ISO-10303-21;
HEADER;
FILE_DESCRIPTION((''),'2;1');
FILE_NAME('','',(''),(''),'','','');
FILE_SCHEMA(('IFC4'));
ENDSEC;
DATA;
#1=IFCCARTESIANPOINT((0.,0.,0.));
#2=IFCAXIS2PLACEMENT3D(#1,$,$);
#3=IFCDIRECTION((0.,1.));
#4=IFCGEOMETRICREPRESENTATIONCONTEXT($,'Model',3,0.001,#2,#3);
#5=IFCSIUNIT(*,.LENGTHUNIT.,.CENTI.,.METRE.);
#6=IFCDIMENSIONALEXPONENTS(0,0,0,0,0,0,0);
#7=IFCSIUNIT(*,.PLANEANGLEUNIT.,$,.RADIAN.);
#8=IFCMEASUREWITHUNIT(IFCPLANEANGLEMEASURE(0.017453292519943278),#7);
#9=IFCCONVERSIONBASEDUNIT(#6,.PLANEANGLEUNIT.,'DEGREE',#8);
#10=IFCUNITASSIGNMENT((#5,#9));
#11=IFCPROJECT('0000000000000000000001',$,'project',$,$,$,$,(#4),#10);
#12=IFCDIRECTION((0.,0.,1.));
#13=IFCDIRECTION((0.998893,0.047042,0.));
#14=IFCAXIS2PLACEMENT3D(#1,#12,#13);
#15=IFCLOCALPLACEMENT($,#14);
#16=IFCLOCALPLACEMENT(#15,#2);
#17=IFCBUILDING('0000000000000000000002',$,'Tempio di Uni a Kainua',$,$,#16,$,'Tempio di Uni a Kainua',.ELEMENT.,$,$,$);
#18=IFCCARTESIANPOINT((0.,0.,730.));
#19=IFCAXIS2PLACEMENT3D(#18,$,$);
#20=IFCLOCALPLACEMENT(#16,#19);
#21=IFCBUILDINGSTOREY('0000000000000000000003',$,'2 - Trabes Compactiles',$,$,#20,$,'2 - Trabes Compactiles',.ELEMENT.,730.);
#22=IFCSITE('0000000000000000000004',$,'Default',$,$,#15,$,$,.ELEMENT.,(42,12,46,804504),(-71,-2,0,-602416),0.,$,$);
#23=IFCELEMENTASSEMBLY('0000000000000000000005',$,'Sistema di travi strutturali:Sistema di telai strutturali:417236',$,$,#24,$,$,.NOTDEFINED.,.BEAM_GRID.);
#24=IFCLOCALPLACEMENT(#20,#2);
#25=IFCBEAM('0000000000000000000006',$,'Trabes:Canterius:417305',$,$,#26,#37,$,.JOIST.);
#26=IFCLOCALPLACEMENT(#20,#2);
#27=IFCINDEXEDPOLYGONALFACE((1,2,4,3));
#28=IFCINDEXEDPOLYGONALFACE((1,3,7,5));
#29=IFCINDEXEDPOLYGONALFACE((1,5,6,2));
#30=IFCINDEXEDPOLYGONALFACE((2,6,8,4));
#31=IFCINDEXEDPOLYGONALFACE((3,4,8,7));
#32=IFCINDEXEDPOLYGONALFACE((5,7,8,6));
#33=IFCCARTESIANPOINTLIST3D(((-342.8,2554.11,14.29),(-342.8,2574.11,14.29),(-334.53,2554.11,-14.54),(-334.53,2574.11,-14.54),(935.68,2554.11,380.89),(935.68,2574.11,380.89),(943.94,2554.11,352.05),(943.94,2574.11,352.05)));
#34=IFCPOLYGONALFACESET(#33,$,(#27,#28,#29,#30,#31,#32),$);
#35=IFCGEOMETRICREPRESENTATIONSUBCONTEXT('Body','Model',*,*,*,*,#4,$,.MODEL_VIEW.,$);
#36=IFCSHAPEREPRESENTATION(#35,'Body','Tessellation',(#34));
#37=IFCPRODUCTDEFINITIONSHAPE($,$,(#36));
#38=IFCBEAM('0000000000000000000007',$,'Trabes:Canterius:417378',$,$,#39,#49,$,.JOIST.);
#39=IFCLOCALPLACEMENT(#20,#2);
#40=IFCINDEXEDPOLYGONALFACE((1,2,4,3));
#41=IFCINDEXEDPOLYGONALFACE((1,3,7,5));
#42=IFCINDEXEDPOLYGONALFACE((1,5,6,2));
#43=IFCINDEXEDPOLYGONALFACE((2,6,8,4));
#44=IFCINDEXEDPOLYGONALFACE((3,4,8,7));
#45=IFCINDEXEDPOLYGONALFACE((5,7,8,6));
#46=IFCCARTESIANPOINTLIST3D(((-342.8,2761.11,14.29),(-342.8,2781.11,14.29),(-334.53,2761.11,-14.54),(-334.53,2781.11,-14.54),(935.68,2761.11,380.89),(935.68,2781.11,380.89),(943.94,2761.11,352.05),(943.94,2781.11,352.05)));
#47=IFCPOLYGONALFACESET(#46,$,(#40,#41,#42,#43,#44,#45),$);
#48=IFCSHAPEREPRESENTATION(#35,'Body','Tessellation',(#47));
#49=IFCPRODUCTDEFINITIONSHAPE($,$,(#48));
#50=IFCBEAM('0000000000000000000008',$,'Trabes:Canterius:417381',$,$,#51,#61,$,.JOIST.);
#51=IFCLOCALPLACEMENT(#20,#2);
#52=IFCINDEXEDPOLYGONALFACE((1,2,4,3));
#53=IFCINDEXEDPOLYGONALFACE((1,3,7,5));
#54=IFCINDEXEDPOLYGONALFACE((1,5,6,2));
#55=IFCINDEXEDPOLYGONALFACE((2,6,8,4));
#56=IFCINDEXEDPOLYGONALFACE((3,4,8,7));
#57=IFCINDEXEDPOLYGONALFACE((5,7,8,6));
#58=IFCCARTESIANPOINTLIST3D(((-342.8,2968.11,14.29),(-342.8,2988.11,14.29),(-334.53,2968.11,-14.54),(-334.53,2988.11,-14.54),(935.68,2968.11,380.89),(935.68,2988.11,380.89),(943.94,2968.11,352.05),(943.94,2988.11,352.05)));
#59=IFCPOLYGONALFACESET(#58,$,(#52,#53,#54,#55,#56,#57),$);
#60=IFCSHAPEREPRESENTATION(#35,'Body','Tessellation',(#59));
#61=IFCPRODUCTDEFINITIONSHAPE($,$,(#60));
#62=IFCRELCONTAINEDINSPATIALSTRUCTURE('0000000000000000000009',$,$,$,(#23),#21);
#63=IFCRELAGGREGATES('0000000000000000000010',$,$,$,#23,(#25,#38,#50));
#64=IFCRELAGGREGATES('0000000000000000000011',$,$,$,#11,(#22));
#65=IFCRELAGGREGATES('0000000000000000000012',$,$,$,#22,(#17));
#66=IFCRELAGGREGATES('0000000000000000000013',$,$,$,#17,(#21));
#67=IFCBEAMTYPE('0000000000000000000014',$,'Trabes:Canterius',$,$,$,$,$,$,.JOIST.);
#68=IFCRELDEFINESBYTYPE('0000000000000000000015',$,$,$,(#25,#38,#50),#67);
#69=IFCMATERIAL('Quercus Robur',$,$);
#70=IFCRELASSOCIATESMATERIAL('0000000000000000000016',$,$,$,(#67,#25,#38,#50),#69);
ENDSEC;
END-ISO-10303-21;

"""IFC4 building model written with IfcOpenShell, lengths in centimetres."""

from ifc_helpers import new_model, entity, si_unit, converted_unit, direction, frame, origin, origin_2d_with_axis, place, context, subcontext, project, spatial, rectangle, extrude, source, transform, mapped, material, material_profile, profile_set, profile_usage, type_object, type_shapes, element, aggregate, save


model = new_model("IFC4")

# Units and contexts
model_context = context("Model", 3, precision=0.001, world=origin(), true_north=direction((0.0, 1.0)))
body_context = subcontext(model_context, "Body", "Model", "MODEL_VIEW")
ifc_project = project(units=[si_unit("LENGTHUNIT", "METRE", prefix="CENTI"), converted_unit("PLANEANGLEUNIT", "DEGREE", entity("IfcPlaneAngleMeasure", 0.017453292519943278), si_unit("PLANEANGLEUNIT", "RADIAN"), dimensions=[0, 0, 0, 0, 0, 0, 0])], contexts=[model_context])

# Site, building, storey
site_placement = place(None, frame((0.0, 0.0, 0.0), z_axis=(0.0, 0.0, 1.0), x_axis=(0.998893, 0.047042, 0.0)))
site = spatial("IfcSite", under=ifc_project, at=site_placement, Name="Default", CompositionType="ELEMENT", RefLatitude=(42, 12, 46, 804504), RefLongitude=(-71, -2, 0, -602416), RefElevation=0.0)
building_placement = place(site_placement, origin())
building = spatial("IfcBuilding", under=site, at=building_placement, Name="Tempio di Uni a Kainua", LongName="Tempio di Uni a Kainua", CompositionType="ELEMENT")
storey_placement = place(building_placement, frame((0.0, 0.0, 730.0)))
storey = spatial("IfcBuildingStorey", under=building, at=storey_placement, Name="2 - Trabes Compactiles", LongName="2 - Trabes Compactiles", CompositionType="ELEMENT", Elevation=730.0)

# Shared definitions
ifc_material = material(Name="Quercus Robur")

# Element assembly, beams
assembly_1_placement = place(storey_placement, origin())
assembly_1 = element("IfcElementAssembly", 1, at=assembly_1_placement, inside=storey, Name="Sistema di travi strutturali:Sistema di telai strutturali:417236", AssemblyPlace="NOTDEFINED", PredefinedType="BEAM_GRID")
ifc_material_profile_1 = material_profile(ifc_material, rectangle(XDim=2590.0, YDim=20.0, at=origin_2d_with_axis()), Name="Canterius")
ifc_profile_set_1 = profile_set([ifc_material_profile_1], Name="Canterius")
ifc_profile_usage_1 = profile_usage(ifc_profile_set_1, cardinal=8)
beam_type_1 = type_object("IfcBeamType", Name="Trabes:Canterius", PredefinedType="JOIST", material=ifc_profile_set_1)
shared_shape_1 = source(origin(), body_context, "Body", "SweptSolid", [
    extrude(rectangle(XDim=1330.0, YDim=20.0, at=origin_2d_with_axis()), frame((0.0, 0.0, -15.0)), (0.0, 0.0, 1.0), 30.0),
])
type_shapes(beam_type_1, [shared_shape_1])
beam_1_placement = place(assembly_1_placement, frame((300.57, 2564.11, 183.17), z_axis=(-0.275637, 0.0, 0.961262), x_axis=(0.961262, 0.0, 0.275637)))
beam_1 = element("IfcBeam", 2, at=beam_1_placement, type_object=beam_type_1, material=ifc_profile_usage_1, Name="Trabes:Canterius:417305", PredefinedType="JOIST", context=body_context, shape_type="MappedRepresentation", body=[
    mapped(shared_shape_1, transform((0.0, 0.0, 0.0), scale=1.0)),
])
beam_2_placement = place(assembly_1_placement, frame((300.57, 2771.11, 183.17), z_axis=(-0.275637, 0.0, 0.961262), x_axis=(0.961262, 0.0, 0.275637)))
beam_2 = element("IfcBeam", 3, at=beam_2_placement, type_object=beam_type_1, material=ifc_profile_usage_1, Name="Trabes:Canterius:417378", PredefinedType="JOIST", context=body_context, shape_type="MappedRepresentation", body=[
    mapped(shared_shape_1, transform((0.0, 0.0, 0.0), scale=1.0)),
])
beam_3_placement = place(assembly_1_placement, frame((300.57, 2978.11, 183.17), z_axis=(-0.275637, 0.0, 0.961262), x_axis=(0.961262, 0.0, 0.275637)))
beam_3 = element("IfcBeam", 4, at=beam_3_placement, type_object=beam_type_1, material=ifc_profile_usage_1, Name="Trabes:Canterius:417381", PredefinedType="JOIST", context=body_context, shape_type="MappedRepresentation", body=[
    mapped(shared_shape_1, transform((0.0, 0.0, 0.0), scale=1.0)),
])
aggregate(assembly_1, [beam_1, beam_2, beam_3])

save(model, "model.ifc")
